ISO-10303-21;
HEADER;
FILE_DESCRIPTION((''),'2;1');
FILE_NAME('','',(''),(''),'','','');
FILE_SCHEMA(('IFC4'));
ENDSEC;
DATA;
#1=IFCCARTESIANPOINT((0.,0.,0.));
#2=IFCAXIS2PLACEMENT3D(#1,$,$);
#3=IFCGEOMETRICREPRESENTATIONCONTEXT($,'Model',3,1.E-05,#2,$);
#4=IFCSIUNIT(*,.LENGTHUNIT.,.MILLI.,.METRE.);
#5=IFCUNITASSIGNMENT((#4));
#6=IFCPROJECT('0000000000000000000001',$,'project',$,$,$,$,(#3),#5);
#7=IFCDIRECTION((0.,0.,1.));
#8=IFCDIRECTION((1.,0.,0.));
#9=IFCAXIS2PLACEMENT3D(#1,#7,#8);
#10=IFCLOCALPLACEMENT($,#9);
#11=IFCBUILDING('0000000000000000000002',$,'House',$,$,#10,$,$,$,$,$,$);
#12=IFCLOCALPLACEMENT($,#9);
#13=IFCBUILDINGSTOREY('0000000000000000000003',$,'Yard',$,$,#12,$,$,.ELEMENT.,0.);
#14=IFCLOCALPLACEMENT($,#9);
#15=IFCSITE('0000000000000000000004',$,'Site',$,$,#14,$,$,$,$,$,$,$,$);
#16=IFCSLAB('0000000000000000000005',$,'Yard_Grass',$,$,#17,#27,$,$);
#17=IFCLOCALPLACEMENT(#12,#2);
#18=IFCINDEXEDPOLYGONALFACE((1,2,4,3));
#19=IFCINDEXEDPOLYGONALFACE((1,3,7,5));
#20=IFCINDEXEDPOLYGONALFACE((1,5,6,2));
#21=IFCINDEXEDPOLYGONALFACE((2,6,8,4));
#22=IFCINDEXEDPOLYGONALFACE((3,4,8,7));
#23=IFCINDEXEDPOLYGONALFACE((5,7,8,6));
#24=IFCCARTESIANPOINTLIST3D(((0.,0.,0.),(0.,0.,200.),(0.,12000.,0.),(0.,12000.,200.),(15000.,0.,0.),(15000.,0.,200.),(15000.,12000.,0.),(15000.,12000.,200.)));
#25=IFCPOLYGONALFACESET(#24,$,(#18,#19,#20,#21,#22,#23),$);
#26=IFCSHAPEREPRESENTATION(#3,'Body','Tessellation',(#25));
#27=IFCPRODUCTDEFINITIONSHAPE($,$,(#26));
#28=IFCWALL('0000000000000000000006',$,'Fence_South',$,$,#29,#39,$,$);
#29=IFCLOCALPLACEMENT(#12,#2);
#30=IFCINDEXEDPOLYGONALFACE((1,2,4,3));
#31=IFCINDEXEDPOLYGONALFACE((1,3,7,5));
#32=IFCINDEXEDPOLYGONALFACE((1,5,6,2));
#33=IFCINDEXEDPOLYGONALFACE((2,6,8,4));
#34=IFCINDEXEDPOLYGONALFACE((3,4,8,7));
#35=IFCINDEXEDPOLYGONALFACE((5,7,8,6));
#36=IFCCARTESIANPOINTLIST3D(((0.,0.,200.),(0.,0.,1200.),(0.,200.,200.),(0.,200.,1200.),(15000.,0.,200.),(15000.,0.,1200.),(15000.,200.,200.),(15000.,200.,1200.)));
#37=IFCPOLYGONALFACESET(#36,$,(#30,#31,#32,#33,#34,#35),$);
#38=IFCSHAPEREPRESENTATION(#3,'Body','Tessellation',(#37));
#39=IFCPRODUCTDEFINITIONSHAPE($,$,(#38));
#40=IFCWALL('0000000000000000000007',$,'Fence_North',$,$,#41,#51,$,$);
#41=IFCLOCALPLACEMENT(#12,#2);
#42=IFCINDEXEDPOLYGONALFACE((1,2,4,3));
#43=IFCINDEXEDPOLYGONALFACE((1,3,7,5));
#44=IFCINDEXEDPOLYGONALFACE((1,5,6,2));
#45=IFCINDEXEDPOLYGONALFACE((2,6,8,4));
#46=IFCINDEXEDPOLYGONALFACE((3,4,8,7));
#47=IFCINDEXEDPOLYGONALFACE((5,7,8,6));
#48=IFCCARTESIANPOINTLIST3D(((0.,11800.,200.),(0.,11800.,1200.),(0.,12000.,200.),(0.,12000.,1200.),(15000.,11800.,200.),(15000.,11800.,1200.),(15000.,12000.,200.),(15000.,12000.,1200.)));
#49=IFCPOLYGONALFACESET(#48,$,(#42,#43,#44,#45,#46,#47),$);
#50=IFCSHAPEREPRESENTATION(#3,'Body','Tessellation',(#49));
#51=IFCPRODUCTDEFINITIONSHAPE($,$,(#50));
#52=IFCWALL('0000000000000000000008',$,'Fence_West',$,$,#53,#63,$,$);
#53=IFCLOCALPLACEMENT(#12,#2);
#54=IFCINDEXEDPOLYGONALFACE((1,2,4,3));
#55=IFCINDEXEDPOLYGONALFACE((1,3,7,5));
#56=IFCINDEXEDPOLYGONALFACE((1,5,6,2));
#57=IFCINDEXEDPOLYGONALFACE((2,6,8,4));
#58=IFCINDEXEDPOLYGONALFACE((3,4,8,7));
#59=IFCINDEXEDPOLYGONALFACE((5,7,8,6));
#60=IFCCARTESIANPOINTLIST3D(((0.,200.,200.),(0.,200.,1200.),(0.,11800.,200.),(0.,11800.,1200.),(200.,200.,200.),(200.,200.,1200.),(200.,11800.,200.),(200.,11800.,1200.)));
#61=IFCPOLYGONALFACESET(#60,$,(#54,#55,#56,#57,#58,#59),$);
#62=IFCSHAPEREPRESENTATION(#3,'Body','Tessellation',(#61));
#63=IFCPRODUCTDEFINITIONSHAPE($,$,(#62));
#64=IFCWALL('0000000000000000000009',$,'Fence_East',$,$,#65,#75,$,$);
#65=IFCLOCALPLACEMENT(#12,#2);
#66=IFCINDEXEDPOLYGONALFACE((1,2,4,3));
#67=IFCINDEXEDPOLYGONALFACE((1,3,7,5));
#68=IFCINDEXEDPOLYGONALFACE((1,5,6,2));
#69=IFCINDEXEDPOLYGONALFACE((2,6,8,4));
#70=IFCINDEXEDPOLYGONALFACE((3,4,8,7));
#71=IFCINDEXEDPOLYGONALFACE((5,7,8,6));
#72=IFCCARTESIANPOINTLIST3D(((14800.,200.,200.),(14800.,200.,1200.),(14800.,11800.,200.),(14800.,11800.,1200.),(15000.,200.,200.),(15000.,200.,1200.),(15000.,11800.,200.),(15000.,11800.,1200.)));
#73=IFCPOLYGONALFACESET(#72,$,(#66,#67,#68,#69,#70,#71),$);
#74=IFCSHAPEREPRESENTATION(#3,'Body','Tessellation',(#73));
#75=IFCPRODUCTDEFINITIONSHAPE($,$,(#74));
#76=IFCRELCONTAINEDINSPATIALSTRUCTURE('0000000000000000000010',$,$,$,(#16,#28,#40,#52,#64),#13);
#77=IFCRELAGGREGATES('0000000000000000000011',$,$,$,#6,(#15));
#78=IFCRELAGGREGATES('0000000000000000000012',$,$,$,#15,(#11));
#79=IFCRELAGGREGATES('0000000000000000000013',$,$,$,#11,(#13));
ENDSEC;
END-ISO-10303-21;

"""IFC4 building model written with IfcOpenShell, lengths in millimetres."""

from ifc_helpers import new_model, si_unit, frame, origin, origin_with_axes, place, context, project, spatial, rectangle, extrude, element, save


model = new_model("IFC4")

# Units and contexts
model_context = context("Model", 3, precision=1e-05, world=origin())
ifc_project = project(units=[si_unit("LENGTHUNIT", "METRE", prefix="MILLI")], contexts=[model_context])

# Site, building, storey
site_placement = place(None, origin_with_axes())
site = spatial("IfcSite", under=ifc_project, at=site_placement, Name="Site")
building_placement = place(None, origin_with_axes())
building = spatial("IfcBuilding", under=site, at=building_placement, Name="House")
storey_placement = place(None, origin_with_axes())
storey = spatial("IfcBuildingStorey", under=building, at=storey_placement, Name="Yard", CompositionType="ELEMENT", Elevation=0.0)

# Slab
slab_placement = place(None, origin_with_axes())
element("IfcSlab", 1, at=slab_placement, inside=storey, Name="Yard_Grass", context=model_context, shape_type="SweptSolid", body=[
    extrude(rectangle(XDim=15000.0, YDim=12000.0), frame((7500.0, 6000.0, 0.0)), (0.0, 0.0, 1.0), 200.0),
])

# Walls
for number, where, z_axis, x_axis, name in (
    (2, (0.0, 0.0, 200.0), (0.0, 0.0, 1.0), (1.0, 0.0, 0.0), "Fence_South"),
    (3, (0.0, 11800.0, 200.0), (0.0, 0.0, 1.0), (1.0, 0.0, 0.0), "Fence_North"),
):
    element("IfcWall", number, at=place(None, frame(where, z_axis=z_axis, x_axis=x_axis)), inside=storey, Name=name, context=model_context, shape_type="SweptSolid", body=[
        extrude(rectangle(XDim=15000.0, YDim=200.0), frame((7500.0, 100.0, 0.0)), (0.0, 0.0, 1.0), 1000.0),
    ])
for number, where, z_axis, x_axis, name in (
    (4, (0.0, 200.0, 200.0), (0.0, 0.0, 1.0), (1.0, 0.0, 0.0), "Fence_West"),
    (5, (14800.0, 200.0, 200.0), (0.0, 0.0, 1.0), (1.0, 0.0, 0.0), "Fence_East"),
):
    element("IfcWall", number, at=place(None, frame(where, z_axis=z_axis, x_axis=x_axis)), inside=storey, Name=name, context=model_context, shape_type="SweptSolid", body=[
        extrude(rectangle(XDim=200.0, YDim=11600.0), frame((100.0, 5800.0, 0.0)), (0.0, 0.0, 1.0), 1000.0),
    ])

save(model, "model.ifc")
